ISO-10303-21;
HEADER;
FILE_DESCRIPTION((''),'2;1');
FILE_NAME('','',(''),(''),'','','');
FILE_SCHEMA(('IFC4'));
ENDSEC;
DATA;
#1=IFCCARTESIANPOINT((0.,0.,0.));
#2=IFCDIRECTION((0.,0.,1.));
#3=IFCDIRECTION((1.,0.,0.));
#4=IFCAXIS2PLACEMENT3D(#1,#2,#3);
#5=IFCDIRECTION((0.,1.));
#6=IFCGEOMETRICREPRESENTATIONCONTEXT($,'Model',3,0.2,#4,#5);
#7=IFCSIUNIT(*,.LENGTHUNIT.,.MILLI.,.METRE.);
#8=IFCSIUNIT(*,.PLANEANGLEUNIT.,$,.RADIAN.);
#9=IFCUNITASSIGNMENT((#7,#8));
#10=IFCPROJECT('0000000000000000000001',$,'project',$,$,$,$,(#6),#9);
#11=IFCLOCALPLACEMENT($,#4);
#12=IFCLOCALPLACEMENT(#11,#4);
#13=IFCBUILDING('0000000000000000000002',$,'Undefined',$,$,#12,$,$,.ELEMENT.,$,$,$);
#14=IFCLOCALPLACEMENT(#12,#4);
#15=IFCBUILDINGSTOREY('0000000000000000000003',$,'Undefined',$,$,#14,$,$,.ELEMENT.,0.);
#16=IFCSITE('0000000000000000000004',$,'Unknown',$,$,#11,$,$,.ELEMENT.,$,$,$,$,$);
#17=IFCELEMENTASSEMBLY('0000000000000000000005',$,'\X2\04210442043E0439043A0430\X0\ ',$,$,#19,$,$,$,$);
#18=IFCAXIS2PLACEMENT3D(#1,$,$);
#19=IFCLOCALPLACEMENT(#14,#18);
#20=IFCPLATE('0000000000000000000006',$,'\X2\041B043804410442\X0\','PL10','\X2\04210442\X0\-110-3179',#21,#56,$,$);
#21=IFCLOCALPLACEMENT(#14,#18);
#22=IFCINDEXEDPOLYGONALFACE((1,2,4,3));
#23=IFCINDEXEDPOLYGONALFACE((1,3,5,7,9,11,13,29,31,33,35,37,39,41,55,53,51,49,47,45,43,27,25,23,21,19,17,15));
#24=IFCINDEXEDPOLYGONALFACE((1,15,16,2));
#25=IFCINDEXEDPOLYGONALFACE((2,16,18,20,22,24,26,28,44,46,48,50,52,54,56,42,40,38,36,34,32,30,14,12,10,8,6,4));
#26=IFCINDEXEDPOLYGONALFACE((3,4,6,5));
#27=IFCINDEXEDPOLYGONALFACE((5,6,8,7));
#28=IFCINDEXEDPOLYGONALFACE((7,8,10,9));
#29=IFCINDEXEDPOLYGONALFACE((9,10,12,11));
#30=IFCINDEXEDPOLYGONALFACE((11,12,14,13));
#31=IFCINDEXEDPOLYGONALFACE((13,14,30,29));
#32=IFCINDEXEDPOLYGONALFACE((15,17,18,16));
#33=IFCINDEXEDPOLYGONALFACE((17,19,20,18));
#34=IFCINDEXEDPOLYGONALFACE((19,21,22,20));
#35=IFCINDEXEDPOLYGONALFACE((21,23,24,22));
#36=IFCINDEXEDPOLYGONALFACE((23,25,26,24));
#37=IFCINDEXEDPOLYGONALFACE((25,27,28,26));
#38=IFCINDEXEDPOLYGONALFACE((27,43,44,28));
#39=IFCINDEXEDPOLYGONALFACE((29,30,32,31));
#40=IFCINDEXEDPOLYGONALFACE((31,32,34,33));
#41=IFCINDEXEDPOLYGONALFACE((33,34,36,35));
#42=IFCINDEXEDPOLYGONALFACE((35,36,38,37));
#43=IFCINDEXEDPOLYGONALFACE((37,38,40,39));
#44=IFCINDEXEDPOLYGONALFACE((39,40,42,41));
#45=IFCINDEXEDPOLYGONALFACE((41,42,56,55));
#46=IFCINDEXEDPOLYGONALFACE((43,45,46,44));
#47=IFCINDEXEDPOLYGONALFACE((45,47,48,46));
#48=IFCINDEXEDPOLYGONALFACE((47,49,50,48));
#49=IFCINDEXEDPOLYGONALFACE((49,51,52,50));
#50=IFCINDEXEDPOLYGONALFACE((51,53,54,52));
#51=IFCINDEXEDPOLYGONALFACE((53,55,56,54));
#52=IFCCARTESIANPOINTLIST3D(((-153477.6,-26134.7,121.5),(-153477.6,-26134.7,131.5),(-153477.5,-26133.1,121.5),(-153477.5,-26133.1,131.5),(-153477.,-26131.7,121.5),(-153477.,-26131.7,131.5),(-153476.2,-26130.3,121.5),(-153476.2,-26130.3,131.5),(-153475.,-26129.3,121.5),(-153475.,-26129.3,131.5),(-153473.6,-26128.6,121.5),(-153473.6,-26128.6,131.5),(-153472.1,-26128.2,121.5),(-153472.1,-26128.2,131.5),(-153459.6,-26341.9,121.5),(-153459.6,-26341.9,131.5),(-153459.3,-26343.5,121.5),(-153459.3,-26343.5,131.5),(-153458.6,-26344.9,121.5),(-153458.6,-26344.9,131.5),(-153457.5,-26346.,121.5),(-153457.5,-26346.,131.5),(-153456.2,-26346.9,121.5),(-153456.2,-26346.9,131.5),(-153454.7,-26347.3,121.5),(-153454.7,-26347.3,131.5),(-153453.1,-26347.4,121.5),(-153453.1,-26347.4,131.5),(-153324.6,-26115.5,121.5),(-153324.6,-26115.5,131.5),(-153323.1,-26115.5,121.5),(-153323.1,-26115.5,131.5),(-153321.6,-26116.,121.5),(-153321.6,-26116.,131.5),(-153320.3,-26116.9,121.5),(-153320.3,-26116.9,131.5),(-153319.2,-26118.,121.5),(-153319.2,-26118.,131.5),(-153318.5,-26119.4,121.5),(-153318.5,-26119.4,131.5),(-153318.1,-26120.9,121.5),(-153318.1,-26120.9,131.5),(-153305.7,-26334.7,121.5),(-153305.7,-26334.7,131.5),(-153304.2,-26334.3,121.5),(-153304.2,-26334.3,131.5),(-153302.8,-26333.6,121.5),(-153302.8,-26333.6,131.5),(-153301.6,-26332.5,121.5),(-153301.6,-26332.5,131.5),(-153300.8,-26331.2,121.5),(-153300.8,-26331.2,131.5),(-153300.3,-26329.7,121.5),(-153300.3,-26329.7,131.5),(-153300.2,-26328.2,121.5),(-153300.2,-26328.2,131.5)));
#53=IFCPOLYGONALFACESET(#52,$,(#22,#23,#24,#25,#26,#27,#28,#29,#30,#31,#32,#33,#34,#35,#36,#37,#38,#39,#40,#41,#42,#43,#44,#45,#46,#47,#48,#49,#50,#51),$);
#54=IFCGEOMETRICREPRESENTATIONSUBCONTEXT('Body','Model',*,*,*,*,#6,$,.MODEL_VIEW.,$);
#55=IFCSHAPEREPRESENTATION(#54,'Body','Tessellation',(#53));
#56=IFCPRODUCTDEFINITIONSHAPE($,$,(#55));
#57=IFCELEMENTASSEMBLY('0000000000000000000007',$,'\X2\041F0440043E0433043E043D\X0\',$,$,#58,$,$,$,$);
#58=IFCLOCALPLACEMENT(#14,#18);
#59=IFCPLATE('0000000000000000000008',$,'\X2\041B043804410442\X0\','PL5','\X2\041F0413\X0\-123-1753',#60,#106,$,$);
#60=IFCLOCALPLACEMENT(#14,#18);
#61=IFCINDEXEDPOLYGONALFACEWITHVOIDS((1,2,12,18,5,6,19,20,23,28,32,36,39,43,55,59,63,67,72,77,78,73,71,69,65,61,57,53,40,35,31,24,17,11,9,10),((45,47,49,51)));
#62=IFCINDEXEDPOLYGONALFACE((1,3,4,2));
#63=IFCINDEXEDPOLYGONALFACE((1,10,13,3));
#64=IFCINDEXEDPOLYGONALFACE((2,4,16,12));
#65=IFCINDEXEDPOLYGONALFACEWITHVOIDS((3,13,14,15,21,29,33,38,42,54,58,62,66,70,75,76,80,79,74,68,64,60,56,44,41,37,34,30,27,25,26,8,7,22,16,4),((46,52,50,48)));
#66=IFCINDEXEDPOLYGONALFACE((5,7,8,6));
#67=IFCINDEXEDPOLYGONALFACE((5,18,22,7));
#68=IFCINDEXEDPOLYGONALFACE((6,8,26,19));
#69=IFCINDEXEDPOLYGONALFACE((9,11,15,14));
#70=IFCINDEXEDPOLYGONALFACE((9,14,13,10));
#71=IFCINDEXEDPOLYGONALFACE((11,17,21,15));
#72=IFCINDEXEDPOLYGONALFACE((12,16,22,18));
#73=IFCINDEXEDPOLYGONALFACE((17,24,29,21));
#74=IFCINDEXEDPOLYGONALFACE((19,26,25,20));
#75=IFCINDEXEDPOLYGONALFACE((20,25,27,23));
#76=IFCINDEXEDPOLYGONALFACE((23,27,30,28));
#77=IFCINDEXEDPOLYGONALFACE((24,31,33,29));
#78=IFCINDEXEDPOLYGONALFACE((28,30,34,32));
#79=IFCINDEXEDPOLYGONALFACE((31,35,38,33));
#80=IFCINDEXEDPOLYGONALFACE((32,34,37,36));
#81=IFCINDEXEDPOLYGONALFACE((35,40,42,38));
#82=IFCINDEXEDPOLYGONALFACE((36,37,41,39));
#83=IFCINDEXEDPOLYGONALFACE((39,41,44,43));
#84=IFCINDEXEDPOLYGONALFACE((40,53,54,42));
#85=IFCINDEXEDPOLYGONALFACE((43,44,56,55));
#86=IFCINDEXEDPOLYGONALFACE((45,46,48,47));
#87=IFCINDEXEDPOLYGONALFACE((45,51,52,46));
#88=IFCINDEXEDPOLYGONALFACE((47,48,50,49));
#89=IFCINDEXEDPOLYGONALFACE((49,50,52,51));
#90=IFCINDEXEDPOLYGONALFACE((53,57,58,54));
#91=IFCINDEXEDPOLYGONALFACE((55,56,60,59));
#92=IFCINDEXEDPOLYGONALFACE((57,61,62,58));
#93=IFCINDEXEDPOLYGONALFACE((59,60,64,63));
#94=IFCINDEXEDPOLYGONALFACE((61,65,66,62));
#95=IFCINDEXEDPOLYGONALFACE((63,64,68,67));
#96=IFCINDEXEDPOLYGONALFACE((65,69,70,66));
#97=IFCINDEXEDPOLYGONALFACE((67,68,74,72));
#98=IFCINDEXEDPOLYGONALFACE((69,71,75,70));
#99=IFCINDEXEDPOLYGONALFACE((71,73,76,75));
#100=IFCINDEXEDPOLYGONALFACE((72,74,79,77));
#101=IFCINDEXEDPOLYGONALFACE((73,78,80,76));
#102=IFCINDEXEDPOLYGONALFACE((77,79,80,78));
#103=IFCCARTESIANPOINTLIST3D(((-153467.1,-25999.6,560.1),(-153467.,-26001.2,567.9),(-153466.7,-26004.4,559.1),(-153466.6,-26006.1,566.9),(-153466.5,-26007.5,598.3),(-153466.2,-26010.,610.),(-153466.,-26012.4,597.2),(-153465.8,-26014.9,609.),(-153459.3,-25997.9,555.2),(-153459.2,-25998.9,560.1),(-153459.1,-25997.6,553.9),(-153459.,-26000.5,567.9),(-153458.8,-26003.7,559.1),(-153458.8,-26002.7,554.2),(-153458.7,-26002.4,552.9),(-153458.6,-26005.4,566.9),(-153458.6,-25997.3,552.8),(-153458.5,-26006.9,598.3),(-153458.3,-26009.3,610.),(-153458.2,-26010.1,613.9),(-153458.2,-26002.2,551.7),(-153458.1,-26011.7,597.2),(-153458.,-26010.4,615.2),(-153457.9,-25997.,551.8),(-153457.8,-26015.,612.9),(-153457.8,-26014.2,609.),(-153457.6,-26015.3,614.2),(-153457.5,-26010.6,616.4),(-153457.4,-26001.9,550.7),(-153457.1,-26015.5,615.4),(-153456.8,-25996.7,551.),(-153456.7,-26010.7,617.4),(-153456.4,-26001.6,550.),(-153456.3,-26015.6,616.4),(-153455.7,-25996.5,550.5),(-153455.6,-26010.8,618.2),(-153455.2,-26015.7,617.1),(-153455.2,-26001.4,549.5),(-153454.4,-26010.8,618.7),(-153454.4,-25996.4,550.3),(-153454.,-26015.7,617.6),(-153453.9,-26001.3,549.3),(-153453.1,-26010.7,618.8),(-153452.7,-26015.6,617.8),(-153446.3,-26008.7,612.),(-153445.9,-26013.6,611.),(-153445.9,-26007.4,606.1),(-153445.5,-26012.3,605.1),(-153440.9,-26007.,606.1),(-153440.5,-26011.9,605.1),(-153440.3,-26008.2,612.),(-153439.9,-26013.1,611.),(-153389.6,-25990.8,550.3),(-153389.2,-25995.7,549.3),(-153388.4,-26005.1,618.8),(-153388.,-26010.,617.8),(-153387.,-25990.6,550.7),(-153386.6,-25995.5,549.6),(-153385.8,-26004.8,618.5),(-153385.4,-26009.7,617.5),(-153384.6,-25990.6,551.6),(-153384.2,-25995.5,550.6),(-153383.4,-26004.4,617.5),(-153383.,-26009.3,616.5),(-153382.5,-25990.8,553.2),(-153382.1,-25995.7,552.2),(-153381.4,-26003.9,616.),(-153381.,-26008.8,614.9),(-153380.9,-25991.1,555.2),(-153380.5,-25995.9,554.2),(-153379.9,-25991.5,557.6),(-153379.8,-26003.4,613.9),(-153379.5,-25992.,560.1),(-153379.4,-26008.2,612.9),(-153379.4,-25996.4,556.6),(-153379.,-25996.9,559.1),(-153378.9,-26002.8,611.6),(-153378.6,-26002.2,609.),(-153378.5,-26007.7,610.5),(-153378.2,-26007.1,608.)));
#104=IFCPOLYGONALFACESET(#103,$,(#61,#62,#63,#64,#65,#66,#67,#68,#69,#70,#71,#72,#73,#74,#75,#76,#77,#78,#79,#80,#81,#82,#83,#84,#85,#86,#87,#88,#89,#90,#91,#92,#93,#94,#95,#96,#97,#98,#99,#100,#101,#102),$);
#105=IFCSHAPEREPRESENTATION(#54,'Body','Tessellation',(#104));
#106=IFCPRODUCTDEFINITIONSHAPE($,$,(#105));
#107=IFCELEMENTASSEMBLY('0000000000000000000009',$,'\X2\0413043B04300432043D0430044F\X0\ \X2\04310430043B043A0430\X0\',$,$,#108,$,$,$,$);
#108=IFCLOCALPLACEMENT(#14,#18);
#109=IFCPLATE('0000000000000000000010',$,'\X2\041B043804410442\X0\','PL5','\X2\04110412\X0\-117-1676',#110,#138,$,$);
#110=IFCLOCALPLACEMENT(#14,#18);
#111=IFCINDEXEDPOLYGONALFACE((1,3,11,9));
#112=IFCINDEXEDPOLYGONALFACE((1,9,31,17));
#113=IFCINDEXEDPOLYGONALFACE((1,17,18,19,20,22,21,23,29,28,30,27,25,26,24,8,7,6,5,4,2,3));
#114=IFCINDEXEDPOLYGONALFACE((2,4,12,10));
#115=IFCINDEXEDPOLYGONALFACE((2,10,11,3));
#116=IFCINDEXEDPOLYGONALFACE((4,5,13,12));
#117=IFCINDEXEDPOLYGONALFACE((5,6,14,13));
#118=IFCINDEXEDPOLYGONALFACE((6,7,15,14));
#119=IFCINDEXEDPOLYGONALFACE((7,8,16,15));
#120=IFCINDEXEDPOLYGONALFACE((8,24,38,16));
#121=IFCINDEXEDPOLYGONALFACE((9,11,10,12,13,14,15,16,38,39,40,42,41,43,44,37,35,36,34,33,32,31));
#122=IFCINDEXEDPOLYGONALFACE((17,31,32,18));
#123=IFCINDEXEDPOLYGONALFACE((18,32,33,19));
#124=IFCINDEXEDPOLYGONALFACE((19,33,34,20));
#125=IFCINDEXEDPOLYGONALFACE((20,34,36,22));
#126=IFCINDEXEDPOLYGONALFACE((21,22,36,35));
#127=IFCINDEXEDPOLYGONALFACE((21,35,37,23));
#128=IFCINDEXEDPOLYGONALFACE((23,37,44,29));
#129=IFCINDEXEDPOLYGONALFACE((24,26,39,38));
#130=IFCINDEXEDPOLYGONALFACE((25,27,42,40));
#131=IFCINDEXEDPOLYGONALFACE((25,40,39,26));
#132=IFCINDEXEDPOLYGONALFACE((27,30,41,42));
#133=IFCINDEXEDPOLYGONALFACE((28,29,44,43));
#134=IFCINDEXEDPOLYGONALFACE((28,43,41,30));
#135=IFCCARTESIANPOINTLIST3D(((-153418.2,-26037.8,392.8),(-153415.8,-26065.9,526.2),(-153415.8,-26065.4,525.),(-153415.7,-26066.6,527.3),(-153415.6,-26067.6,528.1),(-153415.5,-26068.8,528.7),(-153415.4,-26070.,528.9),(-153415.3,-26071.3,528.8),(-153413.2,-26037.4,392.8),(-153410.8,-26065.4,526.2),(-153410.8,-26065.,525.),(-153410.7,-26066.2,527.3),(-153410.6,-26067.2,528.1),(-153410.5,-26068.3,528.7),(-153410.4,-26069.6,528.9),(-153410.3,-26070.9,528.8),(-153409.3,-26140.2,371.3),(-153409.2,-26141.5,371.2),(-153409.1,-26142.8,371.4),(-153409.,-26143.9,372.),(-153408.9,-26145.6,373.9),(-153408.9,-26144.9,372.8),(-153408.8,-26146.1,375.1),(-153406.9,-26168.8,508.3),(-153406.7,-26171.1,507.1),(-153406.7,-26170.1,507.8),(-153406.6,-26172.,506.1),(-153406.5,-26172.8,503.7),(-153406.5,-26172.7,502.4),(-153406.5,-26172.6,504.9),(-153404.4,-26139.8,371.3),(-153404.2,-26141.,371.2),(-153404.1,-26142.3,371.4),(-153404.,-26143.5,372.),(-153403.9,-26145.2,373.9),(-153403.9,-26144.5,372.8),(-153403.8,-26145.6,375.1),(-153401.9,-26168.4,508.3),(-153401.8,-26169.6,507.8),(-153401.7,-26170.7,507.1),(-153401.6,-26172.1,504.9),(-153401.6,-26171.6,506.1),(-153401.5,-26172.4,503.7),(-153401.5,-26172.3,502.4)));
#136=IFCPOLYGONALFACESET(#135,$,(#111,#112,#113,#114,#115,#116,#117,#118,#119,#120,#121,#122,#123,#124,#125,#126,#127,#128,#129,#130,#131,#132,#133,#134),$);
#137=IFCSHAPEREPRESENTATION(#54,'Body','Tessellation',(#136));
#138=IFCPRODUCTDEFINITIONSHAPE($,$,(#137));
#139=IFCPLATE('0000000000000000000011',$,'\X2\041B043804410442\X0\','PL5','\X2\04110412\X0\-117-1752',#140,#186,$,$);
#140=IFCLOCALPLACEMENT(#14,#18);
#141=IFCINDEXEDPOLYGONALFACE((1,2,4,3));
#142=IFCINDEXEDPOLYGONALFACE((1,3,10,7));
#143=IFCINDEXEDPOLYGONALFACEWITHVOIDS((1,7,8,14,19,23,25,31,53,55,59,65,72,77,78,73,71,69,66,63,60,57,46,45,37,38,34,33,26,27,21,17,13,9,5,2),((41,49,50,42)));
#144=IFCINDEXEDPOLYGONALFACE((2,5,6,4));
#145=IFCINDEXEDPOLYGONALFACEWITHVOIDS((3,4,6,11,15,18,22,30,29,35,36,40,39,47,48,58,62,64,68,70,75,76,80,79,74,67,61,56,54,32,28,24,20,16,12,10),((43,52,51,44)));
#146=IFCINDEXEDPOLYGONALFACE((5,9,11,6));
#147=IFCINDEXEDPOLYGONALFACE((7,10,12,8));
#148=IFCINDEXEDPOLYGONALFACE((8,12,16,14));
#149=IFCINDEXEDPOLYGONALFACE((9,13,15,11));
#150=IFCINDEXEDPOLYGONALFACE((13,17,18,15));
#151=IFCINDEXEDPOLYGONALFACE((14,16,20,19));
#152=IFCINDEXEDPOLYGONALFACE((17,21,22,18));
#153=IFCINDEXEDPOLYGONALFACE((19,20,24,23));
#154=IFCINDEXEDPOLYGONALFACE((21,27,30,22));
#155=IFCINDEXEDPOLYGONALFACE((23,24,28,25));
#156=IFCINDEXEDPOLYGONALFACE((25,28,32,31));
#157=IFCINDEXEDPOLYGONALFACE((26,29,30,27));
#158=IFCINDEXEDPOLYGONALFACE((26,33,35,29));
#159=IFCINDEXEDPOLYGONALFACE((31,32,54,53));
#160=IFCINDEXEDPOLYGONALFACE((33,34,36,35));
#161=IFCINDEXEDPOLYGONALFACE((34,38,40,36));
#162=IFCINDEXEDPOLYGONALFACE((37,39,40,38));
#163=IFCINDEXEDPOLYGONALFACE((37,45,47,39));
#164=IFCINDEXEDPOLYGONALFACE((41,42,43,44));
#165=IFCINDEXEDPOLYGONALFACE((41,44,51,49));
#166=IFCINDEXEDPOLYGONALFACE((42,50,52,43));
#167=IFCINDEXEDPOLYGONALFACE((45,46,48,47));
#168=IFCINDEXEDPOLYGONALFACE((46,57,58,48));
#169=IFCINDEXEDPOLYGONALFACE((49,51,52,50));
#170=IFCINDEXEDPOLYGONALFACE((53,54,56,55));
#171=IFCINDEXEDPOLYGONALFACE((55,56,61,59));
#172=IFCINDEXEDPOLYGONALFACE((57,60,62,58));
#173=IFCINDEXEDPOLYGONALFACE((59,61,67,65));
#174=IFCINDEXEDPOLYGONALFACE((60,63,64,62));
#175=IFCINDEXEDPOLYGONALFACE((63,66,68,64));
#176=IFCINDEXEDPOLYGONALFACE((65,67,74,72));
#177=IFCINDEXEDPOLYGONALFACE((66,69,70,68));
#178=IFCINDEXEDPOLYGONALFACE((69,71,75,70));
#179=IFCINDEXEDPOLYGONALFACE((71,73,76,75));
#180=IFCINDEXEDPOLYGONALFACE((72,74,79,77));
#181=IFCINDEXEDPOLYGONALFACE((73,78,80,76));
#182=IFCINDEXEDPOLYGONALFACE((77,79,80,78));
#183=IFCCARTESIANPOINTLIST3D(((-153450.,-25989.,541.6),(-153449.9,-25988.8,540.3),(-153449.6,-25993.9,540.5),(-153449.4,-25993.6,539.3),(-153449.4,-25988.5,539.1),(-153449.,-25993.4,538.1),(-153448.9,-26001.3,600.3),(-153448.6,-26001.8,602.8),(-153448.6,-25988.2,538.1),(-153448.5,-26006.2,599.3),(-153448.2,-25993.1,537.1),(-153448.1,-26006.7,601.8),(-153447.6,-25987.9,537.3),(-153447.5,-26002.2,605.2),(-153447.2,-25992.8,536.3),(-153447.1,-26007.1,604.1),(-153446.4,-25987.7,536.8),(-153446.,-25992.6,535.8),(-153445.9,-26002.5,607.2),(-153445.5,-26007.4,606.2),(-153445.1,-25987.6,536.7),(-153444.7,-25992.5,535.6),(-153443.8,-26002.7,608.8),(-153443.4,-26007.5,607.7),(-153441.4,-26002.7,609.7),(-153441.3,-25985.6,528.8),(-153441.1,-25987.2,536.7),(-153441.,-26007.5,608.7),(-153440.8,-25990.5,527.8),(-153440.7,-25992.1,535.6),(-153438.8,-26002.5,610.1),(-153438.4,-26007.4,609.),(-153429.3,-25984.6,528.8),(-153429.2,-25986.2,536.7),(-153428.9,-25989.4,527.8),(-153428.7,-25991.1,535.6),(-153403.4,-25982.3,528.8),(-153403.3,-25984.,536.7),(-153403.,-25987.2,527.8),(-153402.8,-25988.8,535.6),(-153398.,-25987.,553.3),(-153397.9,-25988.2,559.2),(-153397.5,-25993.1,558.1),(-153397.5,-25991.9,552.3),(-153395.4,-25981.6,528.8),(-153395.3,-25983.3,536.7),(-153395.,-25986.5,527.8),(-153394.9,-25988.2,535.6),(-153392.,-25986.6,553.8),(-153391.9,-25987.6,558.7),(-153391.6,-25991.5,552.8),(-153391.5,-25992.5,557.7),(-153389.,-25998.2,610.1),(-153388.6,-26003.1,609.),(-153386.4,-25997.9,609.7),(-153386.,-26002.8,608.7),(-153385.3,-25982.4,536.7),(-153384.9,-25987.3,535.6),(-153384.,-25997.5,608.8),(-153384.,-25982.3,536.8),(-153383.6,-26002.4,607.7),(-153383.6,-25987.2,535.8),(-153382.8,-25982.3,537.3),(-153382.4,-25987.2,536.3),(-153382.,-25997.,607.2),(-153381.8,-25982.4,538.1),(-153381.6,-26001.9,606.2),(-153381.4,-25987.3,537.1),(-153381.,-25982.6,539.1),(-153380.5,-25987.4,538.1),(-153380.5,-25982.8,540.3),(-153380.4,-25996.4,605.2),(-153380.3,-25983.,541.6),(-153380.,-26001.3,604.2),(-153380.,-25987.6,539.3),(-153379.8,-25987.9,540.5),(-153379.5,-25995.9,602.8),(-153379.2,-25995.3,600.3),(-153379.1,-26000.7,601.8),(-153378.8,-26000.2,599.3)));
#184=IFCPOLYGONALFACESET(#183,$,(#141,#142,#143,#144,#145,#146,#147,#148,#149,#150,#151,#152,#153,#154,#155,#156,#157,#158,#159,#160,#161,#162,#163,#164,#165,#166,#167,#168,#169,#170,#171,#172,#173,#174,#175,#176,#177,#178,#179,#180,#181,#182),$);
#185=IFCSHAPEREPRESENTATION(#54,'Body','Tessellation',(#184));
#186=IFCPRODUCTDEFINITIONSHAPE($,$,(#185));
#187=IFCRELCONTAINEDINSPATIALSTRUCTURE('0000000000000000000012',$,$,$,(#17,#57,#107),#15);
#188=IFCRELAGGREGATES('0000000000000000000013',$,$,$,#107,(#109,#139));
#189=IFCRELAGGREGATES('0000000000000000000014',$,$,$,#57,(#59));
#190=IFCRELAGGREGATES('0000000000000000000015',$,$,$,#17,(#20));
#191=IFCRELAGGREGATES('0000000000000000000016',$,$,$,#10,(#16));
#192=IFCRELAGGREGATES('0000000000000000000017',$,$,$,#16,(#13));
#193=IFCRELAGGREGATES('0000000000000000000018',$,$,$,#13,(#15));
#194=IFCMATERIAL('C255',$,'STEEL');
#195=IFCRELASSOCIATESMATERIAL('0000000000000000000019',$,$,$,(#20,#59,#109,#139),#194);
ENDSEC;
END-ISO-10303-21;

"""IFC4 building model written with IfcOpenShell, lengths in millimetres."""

from ifc_helpers import new_model, si_unit, direction, frame, origin_with_axes, place, context, subcontext, project, spatial, line, arc, indexed_curve, outline, extrude, material, element, aggregate, save


model = new_model("IFC4")

# Units and contexts
model_context = context("Model", 3, precision=0.2, world=origin_with_axes(), true_north=direction((0.0, 1.0)))
body_context = subcontext(model_context, "Body", "Model", "MODEL_VIEW")
ifc_project = project(units=[si_unit("LENGTHUNIT", "METRE", prefix="MILLI"), si_unit("PLANEANGLEUNIT", "RADIAN")], contexts=[model_context])

# Site, building, storey
site_placement = place(None, origin_with_axes())
site = spatial("IfcSite", under=ifc_project, at=site_placement, Name="Unknown", CompositionType="ELEMENT")
building_placement = place(site_placement, origin_with_axes())
building = spatial("IfcBuilding", under=site, at=building_placement, Name="Undefined", CompositionType="ELEMENT")
storey_placement = place(building_placement, origin_with_axes())
storey = spatial("IfcBuildingStorey", under=building, at=storey_placement, Name="Undefined", CompositionType="ELEMENT", Elevation=0.0)

# Element assembly, plate
ifc_material_1 = material(Name="C255", Category="STEEL")
assembly_1_placement = place(storey_placement, frame((-153388.9, -26231.4, 131.5), z_axis=(-0.086114, 0.996285, 0.0), x_axis=(0.0, 0.0, 1.0)))
assembly_1 = element("IfcElementAssembly", 1, at=assembly_1_placement, inside=storey, Name="Стойка ")
plate_1_placement = place(assembly_1_placement, frame((-5.0, 80.0, -110.0), z_axis=(1.0, 0.0, 0.0), x_axis=(0.0, 0.0, 1.0)))
plate_1 = element("IfcPlate", 2, at=plate_1_placement, material=ifc_material_1, Name="Лист", Description="PL10", ObjectType="Ст-110-3179", context=body_context, shape_type="SolidModel", body=[
    extrude(outline(indexed_curve([(0.0, 6.0), (1.8, 1.8), (6.0, 0.0), (214.0, 0.0), (218.2, 1.8), (220.0, 6.0), (220.0, 154.0), (218.2, 158.2), (214.0, 160.0), (6.0, 160.0), (1.8, 158.2), (0.0, 154.0)], segments=[arc(1, 2, 3), line(3, 4), arc(4, 5, 6), line(6, 7), arc(7, 8, 9), line(9, 10), arc(10, 11, 12), line(12, 1)])), frame((0.0, 0.0, 5.0), z_axis=(0.0, 0.0, 1.0), x_axis=(1.0, 0.0, 0.0)), (0.0, 0.0, -1.0), 10.0),
])

# Element assembly, plate, voiding feature
assembly_2_placement = place(storey_placement, frame((-153498.6, -26006.9, 89.2), z_axis=(0.086114, -0.996285, 0.0), x_axis=(0.0, 0.0, 1.0)))
assembly_2 = element("IfcElementAssembly", 3, at=assembly_2_placement, inside=storey, Name="Прогон")
plate_2_placement = place(assembly_2_placement, frame((460.6, -120.0, -4.2), z_axis=(-0.205517, -0.000052, 0.978653), x_axis=(0.978653, 0.00003, 0.205517)))
plate_2 = element("IfcPlate", 4, at=plate_2_placement, material=ifc_material_1, Name="Лист", Description="PL5", ObjectType="ПГ-123-1753", context=body_context, shape_type="SolidModel", body=[
    extrude(outline(indexed_curve([(0.0, 10.0), (2.9, 2.9), (10.0, 0.0), (60.0, 0.0), (67.1, 2.9), (70.0, 10.0), (70.0, 75.0), (68.5, 78.5), (65.0, 80.0), (61.0, 80.0), (61.0, 88.0), (49.0, 88.0), (49.0, 80.0), (18.0, 80.0), (18.0, 88.0), (10.0, 88.0), (10.0, 80.0), (5.0, 80.0), (1.5, 78.5), (0.0, 75.0)], segments=[arc(1, 2, 3), line(3, 4), arc(4, 5, 6), line(6, 7), arc(7, 8, 9), line(9, 10, 11, 12, 13, 14, 15, 16, 17, 18), arc(18, 19, 20), line(20, 1)])), frame((0.0, 0.0, 2.5), z_axis=(0.0, 0.0, 1.0), x_axis=(1.0, 0.0, 0.0)), (0.0, 0.0, -1.0), 5.0),
])
voiding_feature_1_placement = place(plate_2_placement, frame((60.0, 65.0, 6.0), z_axis=(-0.000054, -1.0, 0.000034), x_axis=(0.0, -0.000034, -1.0)))
element("IfcVoidingFeature", 5, at=voiding_feature_1_placement, cuts=plate_2, Name="Балка", ObjectType="(?)", PredefinedType="HOLE", context=body_context, shape_type="SolidModel", body=[
    extrude(outline(indexed_curve([(2.5, -3.0), (3.0, 3.0), (-3.0, 3.0), (-2.5, -3.0)], segments=[line(1, 2, 3, 4, 1)])), frame((0.0, 0.0, 0.0), z_axis=(-1.0, 0.0, 0.0), x_axis=(0.0, 0.0, 1.0)), (0.0, 0.0, -1.0), 12.0),
])

# Element assembly, plates, voiding feature
assembly_3_placement = place(storey_placement, frame((-153597.0, -23940.1, 906.5), z_axis=(-0.996285, -0.086114, 0.000024), x_axis=(0.084276, -0.975018, -0.205517)))
assembly_3 = element("IfcElementAssembly", 6, at=assembly_3_placement, inside=storey, Name="Главная балка")
plate_3_placement = place(assembly_3_placement, frame((2276.0, 70.0, 0.0), z_axis=(0.0, 0.0, -1.0), x_axis=(0.0, -1.0, 0.0)))
plate_3 = element("IfcPlate", 7, at=plate_3_placement, material=ifc_material_1, Name="Лист", Description="PL5", ObjectType="БВ-117-1676", context=body_context, shape_type="SolidModel", body=[
    extrude(outline(indexed_curve([(0.0, 5.0), (1.5, 1.5), (5.0, 0.0), (135.0, 0.0), (138.5, 1.5), (140.0, 5.0), (140.0, 110.0), (5.0, 110.0), (1.5, 108.5), (0.0, 105.0)], segments=[arc(1, 2, 3), line(3, 4), arc(4, 5, 6), line(6, 7, 8), arc(8, 9, 10), line(10, 1)])), frame((0.0, 0.0, 2.5), z_axis=(0.0, 0.0, 1.0), x_axis=(1.0, 0.0, 0.0)), (0.0, 0.0, -1.0), 5.0),
])
plate_4_placement = place(assembly_3_placement, frame((2087.7, 135.0, -40.0), z_axis=(1.0, 0.000054, 0.0), x_axis=(0.0, -0.000054, 1.0)))
plate_4 = element("IfcPlate", 8, at=plate_4_placement, material=ifc_material_1, Name="Лист", Description="PL5", ObjectType="БВ-117-1752", context=body_context, shape_type="SolidModel", body=[
    extrude(outline(indexed_curve([(0.0, 10.0), (2.9, 2.9), (10.0, 0.0), (60.0, 0.0), (67.1, 2.9), (70.0, 10.0), (70.0, 70.0), (68.5, 73.5), (65.0, 75.0), (61.0, 75.0), (61.0, 83.0), (49.0, 83.0), (49.0, 75.0), (23.0, 75.0), (23.0, 83.0), (15.0, 83.0), (15.0, 75.0), (5.0, 75.0), (1.5, 73.5), (0.0, 70.0)], segments=[arc(1, 2, 3), line(3, 4), arc(4, 5, 6), line(6, 7), arc(7, 8, 9), line(9, 10, 11, 12, 13, 14, 15, 16, 17, 18), arc(18, 19, 20), line(20, 1)])), frame((0.0, 0.0, 2.5), z_axis=(0.0, 0.0, 1.0), x_axis=(1.0, 0.0, 0.0)), (0.0, 0.0, -1.0), 5.0),
])
voiding_feature_2_placement = place(plate_4_placement, frame((15.0, 55.0, 10.0), z_axis=(0.007997, -0.999968, -0.000026), x_axis=(0.0, 0.000026, -1.0)))
element("IfcVoidingFeature", 9, at=voiding_feature_2_placement, cuts=plate_4, Name="Балка", ObjectType="(?)", PredefinedType="HOLE", context=body_context, shape_type="SolidModel", body=[
    extrude(outline(indexed_curve([(2.5, -3.0), (3.0, 3.0), (-3.0, 3.0), (-2.5, -3.0)], segments=[line(1, 2, 3, 4, 1)])), frame((0.0, 0.0, 0.0), z_axis=(-1.0, 0.0, 0.0), x_axis=(0.0, 0.0, 1.0)), (0.0, 0.0, -1.0), 20.0),
])
aggregate(assembly_3, [plate_3, plate_4])

aggregate(assembly_2, [plate_2])
aggregate(assembly_1, [plate_1])

save(model, "model.ifc")
